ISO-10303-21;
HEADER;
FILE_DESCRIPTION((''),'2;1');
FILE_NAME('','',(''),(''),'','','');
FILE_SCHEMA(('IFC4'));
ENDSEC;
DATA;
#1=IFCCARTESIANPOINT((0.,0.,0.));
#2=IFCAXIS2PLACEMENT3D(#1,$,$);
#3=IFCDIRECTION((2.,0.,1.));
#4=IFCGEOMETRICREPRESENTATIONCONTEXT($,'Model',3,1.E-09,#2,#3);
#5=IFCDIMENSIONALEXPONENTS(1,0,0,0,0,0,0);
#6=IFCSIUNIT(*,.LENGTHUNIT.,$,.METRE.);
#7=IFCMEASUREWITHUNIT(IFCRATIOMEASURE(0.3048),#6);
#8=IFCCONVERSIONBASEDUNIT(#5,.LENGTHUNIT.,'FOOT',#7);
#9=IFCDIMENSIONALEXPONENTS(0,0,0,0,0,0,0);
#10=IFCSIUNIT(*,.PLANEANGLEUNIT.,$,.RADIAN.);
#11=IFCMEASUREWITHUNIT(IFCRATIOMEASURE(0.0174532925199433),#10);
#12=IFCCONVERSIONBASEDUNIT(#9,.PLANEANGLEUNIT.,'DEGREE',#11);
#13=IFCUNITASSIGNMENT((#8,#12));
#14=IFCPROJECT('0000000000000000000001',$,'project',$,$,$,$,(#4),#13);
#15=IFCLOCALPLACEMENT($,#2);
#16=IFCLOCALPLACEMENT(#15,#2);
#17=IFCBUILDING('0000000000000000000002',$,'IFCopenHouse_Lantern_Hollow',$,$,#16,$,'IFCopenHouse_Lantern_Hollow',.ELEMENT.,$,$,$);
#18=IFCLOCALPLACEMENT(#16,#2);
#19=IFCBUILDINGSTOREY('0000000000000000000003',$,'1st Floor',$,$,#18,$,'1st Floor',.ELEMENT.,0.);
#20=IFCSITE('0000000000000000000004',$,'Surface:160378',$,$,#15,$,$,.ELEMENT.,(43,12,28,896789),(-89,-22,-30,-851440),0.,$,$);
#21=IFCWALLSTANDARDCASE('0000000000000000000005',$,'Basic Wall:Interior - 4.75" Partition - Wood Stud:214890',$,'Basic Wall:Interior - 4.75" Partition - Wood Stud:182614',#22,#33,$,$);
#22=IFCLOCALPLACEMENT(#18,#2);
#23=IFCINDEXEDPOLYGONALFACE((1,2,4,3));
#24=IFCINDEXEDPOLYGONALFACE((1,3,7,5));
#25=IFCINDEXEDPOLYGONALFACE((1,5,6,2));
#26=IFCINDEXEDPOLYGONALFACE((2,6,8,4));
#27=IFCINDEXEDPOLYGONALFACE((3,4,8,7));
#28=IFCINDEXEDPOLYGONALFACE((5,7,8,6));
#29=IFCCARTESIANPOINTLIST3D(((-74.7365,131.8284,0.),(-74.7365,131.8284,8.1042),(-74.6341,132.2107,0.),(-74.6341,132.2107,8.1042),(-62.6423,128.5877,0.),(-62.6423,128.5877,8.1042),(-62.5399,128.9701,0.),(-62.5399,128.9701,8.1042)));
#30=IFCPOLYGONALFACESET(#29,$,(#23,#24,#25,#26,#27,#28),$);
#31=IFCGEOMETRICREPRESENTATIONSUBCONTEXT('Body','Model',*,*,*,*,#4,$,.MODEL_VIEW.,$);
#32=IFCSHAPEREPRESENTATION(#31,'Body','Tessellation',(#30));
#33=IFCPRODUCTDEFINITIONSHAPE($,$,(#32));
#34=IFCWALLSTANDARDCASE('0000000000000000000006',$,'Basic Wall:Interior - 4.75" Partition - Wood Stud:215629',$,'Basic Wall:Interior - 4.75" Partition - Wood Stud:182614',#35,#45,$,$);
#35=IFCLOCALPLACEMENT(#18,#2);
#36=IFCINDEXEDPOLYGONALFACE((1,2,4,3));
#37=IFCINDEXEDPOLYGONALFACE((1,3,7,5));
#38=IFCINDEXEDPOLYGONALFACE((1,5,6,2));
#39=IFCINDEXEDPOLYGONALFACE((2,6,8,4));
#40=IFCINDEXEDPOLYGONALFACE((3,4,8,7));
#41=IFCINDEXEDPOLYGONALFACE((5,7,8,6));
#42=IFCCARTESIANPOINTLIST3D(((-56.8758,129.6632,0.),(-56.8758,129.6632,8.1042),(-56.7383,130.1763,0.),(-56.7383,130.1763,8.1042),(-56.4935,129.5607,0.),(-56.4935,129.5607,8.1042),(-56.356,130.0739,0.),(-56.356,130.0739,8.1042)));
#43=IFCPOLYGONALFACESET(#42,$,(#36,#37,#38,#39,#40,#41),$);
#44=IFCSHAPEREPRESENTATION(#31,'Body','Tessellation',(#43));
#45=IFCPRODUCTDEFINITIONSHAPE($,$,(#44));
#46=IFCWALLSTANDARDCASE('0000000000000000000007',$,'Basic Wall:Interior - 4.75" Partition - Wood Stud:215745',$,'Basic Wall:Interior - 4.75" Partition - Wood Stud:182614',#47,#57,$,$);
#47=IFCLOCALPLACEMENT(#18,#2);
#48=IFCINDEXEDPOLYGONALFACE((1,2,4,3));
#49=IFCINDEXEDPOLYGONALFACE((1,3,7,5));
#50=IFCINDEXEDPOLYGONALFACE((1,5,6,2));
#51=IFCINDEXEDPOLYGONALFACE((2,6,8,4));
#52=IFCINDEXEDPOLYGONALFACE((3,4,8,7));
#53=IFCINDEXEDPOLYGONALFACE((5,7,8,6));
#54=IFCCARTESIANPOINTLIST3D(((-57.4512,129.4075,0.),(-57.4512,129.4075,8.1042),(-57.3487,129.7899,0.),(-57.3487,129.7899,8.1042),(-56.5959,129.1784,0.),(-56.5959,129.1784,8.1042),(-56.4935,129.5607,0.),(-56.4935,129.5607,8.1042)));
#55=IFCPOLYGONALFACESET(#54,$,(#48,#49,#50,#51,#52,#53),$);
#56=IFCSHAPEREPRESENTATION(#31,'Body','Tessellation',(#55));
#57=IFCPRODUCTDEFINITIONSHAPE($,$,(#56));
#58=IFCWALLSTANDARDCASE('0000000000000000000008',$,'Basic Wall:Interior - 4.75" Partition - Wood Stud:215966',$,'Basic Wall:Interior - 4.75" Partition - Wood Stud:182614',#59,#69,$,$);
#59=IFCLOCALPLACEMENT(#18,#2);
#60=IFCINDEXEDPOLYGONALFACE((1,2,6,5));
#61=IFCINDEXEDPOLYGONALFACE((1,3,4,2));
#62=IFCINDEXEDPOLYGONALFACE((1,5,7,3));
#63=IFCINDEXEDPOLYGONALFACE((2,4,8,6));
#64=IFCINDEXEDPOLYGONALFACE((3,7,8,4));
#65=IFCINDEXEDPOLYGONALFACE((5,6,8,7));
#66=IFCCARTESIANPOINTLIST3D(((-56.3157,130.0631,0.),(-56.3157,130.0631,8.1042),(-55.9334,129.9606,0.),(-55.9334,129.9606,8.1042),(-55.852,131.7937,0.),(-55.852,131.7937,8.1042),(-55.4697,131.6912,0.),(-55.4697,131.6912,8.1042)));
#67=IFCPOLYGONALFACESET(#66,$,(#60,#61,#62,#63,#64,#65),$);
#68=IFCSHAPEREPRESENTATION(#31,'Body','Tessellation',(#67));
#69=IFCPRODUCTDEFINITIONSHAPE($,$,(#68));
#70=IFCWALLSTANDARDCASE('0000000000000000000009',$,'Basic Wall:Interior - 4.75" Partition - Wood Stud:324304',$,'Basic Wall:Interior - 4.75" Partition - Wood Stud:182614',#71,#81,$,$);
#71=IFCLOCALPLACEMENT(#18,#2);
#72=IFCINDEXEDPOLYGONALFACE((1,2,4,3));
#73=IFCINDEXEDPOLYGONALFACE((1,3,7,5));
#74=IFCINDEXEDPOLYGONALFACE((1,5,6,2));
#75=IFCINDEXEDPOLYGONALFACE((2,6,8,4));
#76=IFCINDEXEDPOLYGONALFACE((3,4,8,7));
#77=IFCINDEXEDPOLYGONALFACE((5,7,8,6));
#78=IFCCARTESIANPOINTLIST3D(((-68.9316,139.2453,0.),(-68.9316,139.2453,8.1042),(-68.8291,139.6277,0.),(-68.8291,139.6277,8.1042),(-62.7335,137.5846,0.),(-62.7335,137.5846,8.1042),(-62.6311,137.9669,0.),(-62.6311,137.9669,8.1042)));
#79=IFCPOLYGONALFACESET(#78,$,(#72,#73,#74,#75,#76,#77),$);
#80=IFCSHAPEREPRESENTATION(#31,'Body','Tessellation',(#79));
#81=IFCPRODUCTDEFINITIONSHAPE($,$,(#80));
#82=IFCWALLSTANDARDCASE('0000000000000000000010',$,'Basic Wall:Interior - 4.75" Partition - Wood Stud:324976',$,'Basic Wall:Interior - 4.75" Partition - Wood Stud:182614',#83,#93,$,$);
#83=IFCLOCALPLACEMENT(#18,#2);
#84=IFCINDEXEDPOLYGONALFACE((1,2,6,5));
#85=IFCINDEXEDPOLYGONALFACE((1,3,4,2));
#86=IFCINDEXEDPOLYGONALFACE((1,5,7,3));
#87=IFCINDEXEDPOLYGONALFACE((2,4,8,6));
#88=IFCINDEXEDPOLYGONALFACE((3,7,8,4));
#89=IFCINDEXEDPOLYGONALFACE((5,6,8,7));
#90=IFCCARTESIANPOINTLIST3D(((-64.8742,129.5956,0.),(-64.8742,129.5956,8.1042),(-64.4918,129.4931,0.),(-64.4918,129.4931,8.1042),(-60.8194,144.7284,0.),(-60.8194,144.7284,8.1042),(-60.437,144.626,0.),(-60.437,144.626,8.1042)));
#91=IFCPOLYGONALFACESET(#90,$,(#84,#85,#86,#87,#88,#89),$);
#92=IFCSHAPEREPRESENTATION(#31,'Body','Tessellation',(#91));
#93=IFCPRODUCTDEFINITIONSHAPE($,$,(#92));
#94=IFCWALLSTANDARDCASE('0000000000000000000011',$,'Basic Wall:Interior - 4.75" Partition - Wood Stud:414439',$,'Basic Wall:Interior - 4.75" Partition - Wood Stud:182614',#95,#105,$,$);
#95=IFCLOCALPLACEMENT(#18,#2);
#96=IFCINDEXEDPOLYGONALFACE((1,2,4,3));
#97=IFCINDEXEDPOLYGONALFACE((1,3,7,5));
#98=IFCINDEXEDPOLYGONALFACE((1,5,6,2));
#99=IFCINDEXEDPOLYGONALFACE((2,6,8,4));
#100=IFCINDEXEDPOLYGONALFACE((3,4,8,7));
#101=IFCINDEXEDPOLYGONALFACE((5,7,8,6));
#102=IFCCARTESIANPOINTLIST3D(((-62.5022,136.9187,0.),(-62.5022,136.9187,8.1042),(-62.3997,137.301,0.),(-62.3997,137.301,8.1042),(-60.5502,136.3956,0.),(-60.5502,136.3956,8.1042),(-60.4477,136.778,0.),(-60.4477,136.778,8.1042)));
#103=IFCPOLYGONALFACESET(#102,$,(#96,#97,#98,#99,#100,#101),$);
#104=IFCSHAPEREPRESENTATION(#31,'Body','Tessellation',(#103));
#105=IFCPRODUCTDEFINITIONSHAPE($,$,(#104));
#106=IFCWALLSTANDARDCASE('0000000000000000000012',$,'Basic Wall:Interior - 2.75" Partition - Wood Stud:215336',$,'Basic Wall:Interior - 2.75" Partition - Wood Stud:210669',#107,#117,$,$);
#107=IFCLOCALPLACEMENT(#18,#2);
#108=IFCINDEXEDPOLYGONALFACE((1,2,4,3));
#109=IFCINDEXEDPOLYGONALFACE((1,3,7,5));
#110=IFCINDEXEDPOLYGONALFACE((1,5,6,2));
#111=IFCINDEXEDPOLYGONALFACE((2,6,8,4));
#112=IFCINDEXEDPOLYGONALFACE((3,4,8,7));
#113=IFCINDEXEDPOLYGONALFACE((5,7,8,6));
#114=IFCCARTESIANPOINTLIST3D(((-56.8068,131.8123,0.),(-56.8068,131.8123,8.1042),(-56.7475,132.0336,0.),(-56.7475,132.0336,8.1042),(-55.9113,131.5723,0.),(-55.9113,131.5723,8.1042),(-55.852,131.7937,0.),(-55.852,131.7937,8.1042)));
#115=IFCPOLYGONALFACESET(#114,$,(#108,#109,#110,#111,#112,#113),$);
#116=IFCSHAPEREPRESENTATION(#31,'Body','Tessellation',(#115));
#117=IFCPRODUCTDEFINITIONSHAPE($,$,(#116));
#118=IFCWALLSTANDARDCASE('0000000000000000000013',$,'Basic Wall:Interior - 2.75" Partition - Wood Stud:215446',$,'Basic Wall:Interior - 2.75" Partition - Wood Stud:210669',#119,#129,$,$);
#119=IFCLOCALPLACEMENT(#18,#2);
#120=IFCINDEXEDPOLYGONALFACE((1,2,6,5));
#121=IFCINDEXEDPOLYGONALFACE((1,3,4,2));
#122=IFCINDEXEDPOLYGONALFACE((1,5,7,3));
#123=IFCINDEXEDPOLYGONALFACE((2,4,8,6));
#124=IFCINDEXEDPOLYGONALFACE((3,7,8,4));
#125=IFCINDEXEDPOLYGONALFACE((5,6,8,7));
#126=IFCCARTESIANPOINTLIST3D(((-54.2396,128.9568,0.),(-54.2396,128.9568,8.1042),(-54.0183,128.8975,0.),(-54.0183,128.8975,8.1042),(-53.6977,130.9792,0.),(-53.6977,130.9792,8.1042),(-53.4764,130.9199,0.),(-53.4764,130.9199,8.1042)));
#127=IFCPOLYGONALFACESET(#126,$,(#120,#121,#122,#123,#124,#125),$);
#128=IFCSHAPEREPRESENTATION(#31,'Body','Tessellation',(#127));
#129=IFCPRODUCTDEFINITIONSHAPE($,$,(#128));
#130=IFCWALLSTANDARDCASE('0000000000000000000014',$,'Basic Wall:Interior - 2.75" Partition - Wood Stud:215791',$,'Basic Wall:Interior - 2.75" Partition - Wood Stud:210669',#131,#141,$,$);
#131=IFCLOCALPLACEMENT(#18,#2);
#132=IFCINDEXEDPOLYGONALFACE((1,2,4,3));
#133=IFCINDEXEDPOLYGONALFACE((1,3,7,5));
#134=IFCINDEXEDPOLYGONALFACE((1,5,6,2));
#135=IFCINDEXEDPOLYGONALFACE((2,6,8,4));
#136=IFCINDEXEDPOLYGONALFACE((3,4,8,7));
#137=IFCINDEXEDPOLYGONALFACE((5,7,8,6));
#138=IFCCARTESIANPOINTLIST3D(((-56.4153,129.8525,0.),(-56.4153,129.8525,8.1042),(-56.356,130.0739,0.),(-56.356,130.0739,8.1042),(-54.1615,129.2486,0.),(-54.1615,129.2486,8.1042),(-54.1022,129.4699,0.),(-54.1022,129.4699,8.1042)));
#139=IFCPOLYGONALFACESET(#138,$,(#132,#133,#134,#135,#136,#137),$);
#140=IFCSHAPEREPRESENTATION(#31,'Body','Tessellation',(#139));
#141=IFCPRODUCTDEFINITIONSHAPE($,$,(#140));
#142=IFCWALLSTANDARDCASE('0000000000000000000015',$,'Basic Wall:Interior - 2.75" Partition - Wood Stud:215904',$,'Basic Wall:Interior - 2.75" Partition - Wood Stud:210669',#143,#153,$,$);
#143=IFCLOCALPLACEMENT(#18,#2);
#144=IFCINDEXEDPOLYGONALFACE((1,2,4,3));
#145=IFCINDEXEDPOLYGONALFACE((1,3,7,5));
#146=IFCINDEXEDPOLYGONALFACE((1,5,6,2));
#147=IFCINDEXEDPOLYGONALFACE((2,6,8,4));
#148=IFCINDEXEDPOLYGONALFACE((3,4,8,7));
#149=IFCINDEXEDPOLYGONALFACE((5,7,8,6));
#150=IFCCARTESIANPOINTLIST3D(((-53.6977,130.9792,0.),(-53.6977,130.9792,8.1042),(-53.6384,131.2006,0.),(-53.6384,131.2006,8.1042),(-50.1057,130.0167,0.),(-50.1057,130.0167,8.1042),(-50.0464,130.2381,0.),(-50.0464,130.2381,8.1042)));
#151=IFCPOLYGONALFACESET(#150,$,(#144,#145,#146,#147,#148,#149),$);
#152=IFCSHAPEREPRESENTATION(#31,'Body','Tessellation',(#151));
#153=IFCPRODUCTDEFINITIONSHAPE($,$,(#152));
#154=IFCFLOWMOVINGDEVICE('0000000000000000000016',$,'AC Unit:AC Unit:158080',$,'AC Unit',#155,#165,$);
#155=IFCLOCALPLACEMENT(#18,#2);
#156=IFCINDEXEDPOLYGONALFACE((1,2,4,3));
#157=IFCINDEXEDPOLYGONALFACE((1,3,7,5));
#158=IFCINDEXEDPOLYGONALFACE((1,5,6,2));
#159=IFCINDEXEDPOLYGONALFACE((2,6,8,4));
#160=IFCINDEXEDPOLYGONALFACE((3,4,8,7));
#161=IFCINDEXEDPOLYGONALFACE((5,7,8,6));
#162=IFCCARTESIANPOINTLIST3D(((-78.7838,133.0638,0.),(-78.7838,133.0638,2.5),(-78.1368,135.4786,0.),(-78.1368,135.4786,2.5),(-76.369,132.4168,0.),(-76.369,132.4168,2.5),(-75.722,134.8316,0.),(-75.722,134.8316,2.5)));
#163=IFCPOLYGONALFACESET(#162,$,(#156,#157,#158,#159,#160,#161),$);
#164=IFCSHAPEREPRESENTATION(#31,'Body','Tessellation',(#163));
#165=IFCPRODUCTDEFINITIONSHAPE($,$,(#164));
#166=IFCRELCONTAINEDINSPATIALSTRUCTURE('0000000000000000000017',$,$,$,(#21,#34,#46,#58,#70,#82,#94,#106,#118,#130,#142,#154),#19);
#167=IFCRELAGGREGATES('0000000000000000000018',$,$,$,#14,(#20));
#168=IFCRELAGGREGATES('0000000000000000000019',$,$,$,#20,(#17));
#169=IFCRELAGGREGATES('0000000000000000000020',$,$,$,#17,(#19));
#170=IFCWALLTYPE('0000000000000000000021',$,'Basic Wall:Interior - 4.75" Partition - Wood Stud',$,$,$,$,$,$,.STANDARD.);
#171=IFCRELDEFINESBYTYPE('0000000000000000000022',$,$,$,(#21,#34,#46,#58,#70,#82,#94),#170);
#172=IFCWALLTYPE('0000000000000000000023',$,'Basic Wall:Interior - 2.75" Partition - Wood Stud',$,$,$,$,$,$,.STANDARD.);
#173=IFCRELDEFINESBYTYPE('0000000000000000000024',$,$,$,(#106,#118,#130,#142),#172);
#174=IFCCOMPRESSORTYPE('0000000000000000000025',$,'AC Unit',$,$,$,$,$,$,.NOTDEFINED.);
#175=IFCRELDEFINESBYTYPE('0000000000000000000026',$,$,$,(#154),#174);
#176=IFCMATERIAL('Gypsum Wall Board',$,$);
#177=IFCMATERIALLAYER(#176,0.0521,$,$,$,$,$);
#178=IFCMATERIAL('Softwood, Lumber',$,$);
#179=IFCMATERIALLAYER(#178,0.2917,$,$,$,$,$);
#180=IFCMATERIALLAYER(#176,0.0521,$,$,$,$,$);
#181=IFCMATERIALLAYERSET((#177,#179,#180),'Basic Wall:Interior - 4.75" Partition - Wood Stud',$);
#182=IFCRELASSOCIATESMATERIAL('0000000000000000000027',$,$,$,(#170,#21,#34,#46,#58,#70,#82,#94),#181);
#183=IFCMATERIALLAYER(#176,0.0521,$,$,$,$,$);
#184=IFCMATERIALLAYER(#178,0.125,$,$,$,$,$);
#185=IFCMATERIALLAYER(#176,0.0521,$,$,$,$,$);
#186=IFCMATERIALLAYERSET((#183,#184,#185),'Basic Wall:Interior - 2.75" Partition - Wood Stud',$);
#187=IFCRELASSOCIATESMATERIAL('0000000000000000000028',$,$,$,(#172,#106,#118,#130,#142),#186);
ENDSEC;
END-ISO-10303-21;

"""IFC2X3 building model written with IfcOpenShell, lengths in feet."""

from ifc_helpers import new_model, entity, si_unit, converted_unit, direction, frame, frame_2d, origin, place, context, subcontext, project, spatial, rectangle, extrude, source, transform, mapped, material, layer, layer_set, layer_usage, type_object, type_shapes, element, save


model = new_model("IFC2X3")

# Units and contexts
model_context = context("Model", 3, precision=1e-09, world=origin(), true_north=direction((2.0, 0.0, 1.0)))
body_context = subcontext(model_context, "Body", "Model", "MODEL_VIEW")
ifc_project = project(units=[converted_unit("LENGTHUNIT", "FOOT", entity("IfcRatioMeasure", 0.3048), si_unit("LENGTHUNIT", "METRE"), dimensions=[1, 0, 0, 0, 0, 0, 0]), converted_unit("PLANEANGLEUNIT", "DEGREE", entity("IfcRatioMeasure", 0.0174532925199433), si_unit("PLANEANGLEUNIT", "RADIAN"), dimensions=[0, 0, 0, 0, 0, 0, 0])], contexts=[model_context])

# Site, building, storey
site_placement = place(None, origin())
site = spatial("IfcSite", under=ifc_project, at=site_placement, Name="Surface:160378", CompositionType="ELEMENT", RefLatitude=(43, 12, 28, 896789), RefLongitude=(-89, -22, -30, -851440), RefElevation=0.0)
building_placement = place(site_placement, origin())
building = spatial("IfcBuilding", under=site, at=building_placement, Name="IFCopenHouse_Lantern_Hollow", LongName="IFCopenHouse_Lantern_Hollow", CompositionType="ELEMENT")
storey_placement = place(building_placement, origin())
storey = spatial("IfcBuildingStorey", under=building, at=storey_placement, Name="1st Floor", LongName="1st Floor", CompositionType="ELEMENT", Elevation=0.0)

# Shared definitions
ifc_material_1 = material(Name="Gypsum Wall Board")
ifc_layer_1 = layer(ifc_material_1, 0.0521)
ifc_material_2 = material(Name="Softwood, Lumber")
ifc_layer_2 = layer(ifc_material_2, 0.2917)
ifc_layer_3 = layer(ifc_material_1, 0.0521)
ifc_layer_set_1 = layer_set([ifc_layer_1, ifc_layer_2, ifc_layer_3], Name="Basic Wall:Interior - 4.75\" Partition - Wood Stud")
wall_type_1 = type_object("IfcWallType", Name="Basic Wall:Interior - 4.75\" Partition - Wood Stud", PredefinedType="STANDARD", material=ifc_layer_set_1)

# Walls
ifc_layer_usage_1 = layer_usage(ifc_layer_set_1, "AXIS2", "NEGATIVE", 0.1979)
wall_1_placement = place(storey_placement, frame((-62.5911, 128.7789, 0.0), z_axis=(0.0, 0.0, 1.0), x_axis=(-0.965926, 0.258819, 0.0)))
element("IfcWallStandardCase", 1, at=wall_1_placement, inside=storey, type_object=wall_type_1, material=ifc_layer_usage_1, Name="Basic Wall:Interior - 4.75\" Partition - Wood Stud:214890", ObjectType="Basic Wall:Interior - 4.75\" Partition - Wood Stud:182614", context=body_context, shape_type="SweptSolid", body=[
    extrude(rectangle(XDim=12.5208, YDim=0.3958, at=frame_2d((6.2604, 0.0), x_axis=(-1.0, 0.0))), origin(), (0.0, 0.0, 1.0), 8.1042),
])
ifc_layer_usage_2 = layer_usage(ifc_layer_set_1, "AXIS2", "NEGATIVE", 0.1979)
wall_2_placement = place(storey_placement, frame((-56.6846, 129.6119, 0.0), z_axis=(0.0, 0.0, 1.0), x_axis=(0.258819, 0.965926, 0.0)))
element("IfcWallStandardCase", 2, at=wall_2_placement, inside=storey, type_object=wall_type_1, material=ifc_layer_usage_2, Name="Basic Wall:Interior - 4.75\" Partition - Wood Stud:215629", ObjectType="Basic Wall:Interior - 4.75\" Partition - Wood Stud:182614", context=body_context, shape_type="SweptSolid", body=[
    extrude(rectangle(XDim=0.5312, YDim=0.3958, at=frame_2d((0.2656, 0.0), x_axis=(-1.0, 0.0))), origin(), (0.0, 0.0, 1.0), 8.1042),
])
ifc_layer_usage_3 = layer_usage(ifc_layer_set_1, "AXIS2", "NEGATIVE", 0.1979)
wall_3_placement = place(storey_placement, frame((-56.5447, 129.3695, 0.0), z_axis=(0.0, 0.0, 1.0), x_axis=(-0.965926, 0.258819, 0.0)))
element("IfcWallStandardCase", 3, at=wall_3_placement, inside=storey, type_object=wall_type_1, material=ifc_layer_usage_3, Name="Basic Wall:Interior - 4.75\" Partition - Wood Stud:215745", ObjectType="Basic Wall:Interior - 4.75\" Partition - Wood Stud:182614", context=body_context, shape_type="SweptSolid", body=[
    extrude(rectangle(XDim=0.8854, YDim=0.3958, at=frame_2d((0.4427, 0.0), x_axis=(-1.0, 0.0))), origin(), (0.0, 0.0, 1.0), 8.1042),
])
ifc_layer_usage_4 = layer_usage(ifc_layer_set_1, "AXIS2", "NEGATIVE", 0.1979)
wall_4_placement = place(storey_placement, frame((-56.1246, 130.0118, 0.0), z_axis=(0.0, 0.0, 1.0), x_axis=(0.258819, 0.965926, 0.0)))
element("IfcWallStandardCase", 4, at=wall_4_placement, inside=storey, type_object=wall_type_1, material=ifc_layer_usage_4, Name="Basic Wall:Interior - 4.75\" Partition - Wood Stud:215966", ObjectType="Basic Wall:Interior - 4.75\" Partition - Wood Stud:182614", context=body_context, shape_type="SweptSolid", body=[
    extrude(rectangle(XDim=1.7917, YDim=0.3958, at=frame_2d((0.8958, 0.0), x_axis=(-1.0, 0.0))), origin(), (0.0, 0.0, 1.0), 8.1042),
])
ifc_layer_usage_5 = layer_usage(ifc_layer_set_1, "AXIS2", "NEGATIVE", 0.1979)
wall_5_placement = place(storey_placement, frame((-62.6823, 137.7757, 0.0), z_axis=(0.0, 0.0, 1.0), x_axis=(-0.965926, 0.258819, 0.0)))
element("IfcWallStandardCase", 5, at=wall_5_placement, inside=storey, type_object=wall_type_1, material=ifc_layer_usage_5, Name="Basic Wall:Interior - 4.75\" Partition - Wood Stud:324304", ObjectType="Basic Wall:Interior - 4.75\" Partition - Wood Stud:182614", context=body_context, shape_type="SweptSolid", body=[
    extrude(rectangle(XDim=6.4167, YDim=0.3958, at=frame_2d((3.2083, 0.0), x_axis=(-1.0, 0.0))), origin(), (0.0, 0.0, 1.0), 8.1042),
])
ifc_layer_usage_6 = layer_usage(ifc_layer_set_1, "AXIS2", "NEGATIVE", 0.1979)
wall_6_placement = place(storey_placement, frame((-64.683, 129.5443, 0.0), z_axis=(0.0, 0.0, 1.0), x_axis=(0.258819, 0.965926, 0.0)))
element("IfcWallStandardCase", 6, at=wall_6_placement, inside=storey, type_object=wall_type_1, material=ifc_layer_usage_6, Name="Basic Wall:Interior - 4.75\" Partition - Wood Stud:324976", ObjectType="Basic Wall:Interior - 4.75\" Partition - Wood Stud:182614", context=body_context, shape_type="SweptSolid", body=[
    extrude(rectangle(XDim=15.6667, YDim=0.3958, at=frame_2d((7.8333, 0.0), x_axis=(-1.0, 0.0))), origin(), (0.0, 0.0, 1.0), 8.1042),
])
ifc_layer_usage_7 = layer_usage(ifc_layer_set_1, "AXIS2", "NEGATIVE", 0.1979)
wall_7_placement = place(storey_placement, frame((-60.499, 136.5868, 0.0), z_axis=(0.0, 0.0, 1.0), x_axis=(-0.965926, 0.258819, 0.0)))
element("IfcWallStandardCase", 7, at=wall_7_placement, inside=storey, type_object=wall_type_1, material=ifc_layer_usage_7, Name="Basic Wall:Interior - 4.75\" Partition - Wood Stud:414439", ObjectType="Basic Wall:Interior - 4.75\" Partition - Wood Stud:182614", context=body_context, shape_type="SweptSolid", body=[
    extrude(rectangle(XDim=2.0208, YDim=0.3958, at=frame_2d((1.0104, 0.0), x_axis=(-1.0, 0.0))), origin(), (0.0, 0.0, 1.0), 8.1042),
])
ifc_layer_4 = layer(ifc_material_1, 0.0521)
ifc_layer_5 = layer(ifc_material_2, 0.125)
ifc_layer_6 = layer(ifc_material_1, 0.0521)
ifc_layer_set_2 = layer_set([ifc_layer_4, ifc_layer_5, ifc_layer_6], Name="Basic Wall:Interior - 2.75\" Partition - Wood Stud")
ifc_layer_usage_8 = layer_usage(ifc_layer_set_2, "AXIS2", "NEGATIVE", 0.1146)
wall_type_2 = type_object("IfcWallType", Name="Basic Wall:Interior - 2.75\" Partition - Wood Stud", PredefinedType="STANDARD", material=ifc_layer_set_2)
wall_8_placement = place(storey_placement, frame((-56.7772, 131.923, 0.0), z_axis=(0.0, 0.0, 1.0), x_axis=(0.965926, -0.258819, 0.0)))
element("IfcWallStandardCase", 8, at=wall_8_placement, inside=storey, type_object=wall_type_2, material=ifc_layer_usage_8, Name="Basic Wall:Interior - 2.75\" Partition - Wood Stud:215336", ObjectType="Basic Wall:Interior - 2.75\" Partition - Wood Stud:210669", context=body_context, shape_type="SweptSolid", body=[
    extrude(rectangle(XDim=0.9271, YDim=0.2292, at=frame_2d((0.4635, 0.0), x_axis=(-1.0, 0.0))), origin(), (0.0, 0.0, 1.0), 8.1042),
])
ifc_layer_usage_9 = layer_usage(ifc_layer_set_2, "AXIS2", "NEGATIVE", 0.1146)
wall_9_placement = place(storey_placement, frame((-54.129, 128.9271, 0.0), z_axis=(0.0, 0.0, 1.0), x_axis=(0.258819, 0.965926, 0.0)))
element("IfcWallStandardCase", 9, at=wall_9_placement, inside=storey, type_object=wall_type_2, material=ifc_layer_usage_9, Name="Basic Wall:Interior - 2.75\" Partition - Wood Stud:215446", ObjectType="Basic Wall:Interior - 2.75\" Partition - Wood Stud:210669", context=body_context, shape_type="SweptSolid", body=[
    extrude(rectangle(XDim=2.0937, YDim=0.2292, at=frame_2d((1.0469, 0.0), x_axis=(-1.0, 0.0))), origin(), (0.0, 0.0, 1.0), 8.1042),
])
ifc_layer_usage_10 = layer_usage(ifc_layer_set_2, "AXIS2", "NEGATIVE", 0.1146)
wall_10_placement = place(storey_placement, frame((-56.3856, 129.9632, 0.0), z_axis=(0.0, 0.0, 1.0), x_axis=(0.965926, -0.258819, 0.0)))
element("IfcWallStandardCase", 10, at=wall_10_placement, inside=storey, type_object=wall_type_2, material=ifc_layer_usage_10, Name="Basic Wall:Interior - 2.75\" Partition - Wood Stud:215791", ObjectType="Basic Wall:Interior - 2.75\" Partition - Wood Stud:210669", context=body_context, shape_type="SweptSolid", body=[
    extrude(rectangle(XDim=2.3333, YDim=0.2292, at=frame_2d((1.1667, 0.0), x_axis=(-1.0, 0.0))), origin(), (0.0, 0.0, 1.0), 8.1042),
])
ifc_layer_usage_11 = layer_usage(ifc_layer_set_2, "AXIS2", "NEGATIVE", 0.1146)
wall_11_placement = place(storey_placement, frame((-53.6681, 131.0899, 0.0), z_axis=(0.0, 0.0, 1.0), x_axis=(0.965926, -0.258819, 0.0)))
element("IfcWallStandardCase", 11, at=wall_11_placement, inside=storey, type_object=wall_type_2, material=ifc_layer_usage_11, Name="Basic Wall:Interior - 2.75\" Partition - Wood Stud:215904", ObjectType="Basic Wall:Interior - 2.75\" Partition - Wood Stud:210669", context=body_context, shape_type="SweptSolid", body=[
    extrude(rectangle(XDim=3.7188, YDim=0.2292, at=frame_2d((1.8594, 0.0), x_axis=(-1.0, 0.0))), origin(), (0.0, 0.0, 1.0), 8.1042),
])

# Flow moving device
compressor_type = type_object("IfcCompressorType", Name="AC Unit", PredefinedType="NOTDEFINED")
shared_shape_1 = source(origin(), body_context, "Body", "SweptSolid", [
    extrude(rectangle(XDim=2.5, YDim=2.5, at=frame_2d((0.0, 0.0), x_axis=(1.0, 0.0))), frame((1.5309, 1.5309, 0.0), z_axis=(0.0, 0.0, 1.0), x_axis=(0.258819, 0.965926, 0.0)), (0.0, 0.0, 1.0), 2.5),
])
type_shapes(compressor_type, [shared_shape_1])
flow_moving_device_placement = place(storey_placement, frame((-78.7838, 132.4168, 0.0)))
element("IfcFlowMovingDevice", 12, at=flow_moving_device_placement, inside=storey, type_object=compressor_type, Name="AC Unit:AC Unit:158080", ObjectType="AC Unit", context=body_context, shape_type="MappedRepresentation", body=[
    mapped(shared_shape_1, transform((0.0, 0.0, 0.0), scale=1.0)),
])

save(model, "model.ifc")
